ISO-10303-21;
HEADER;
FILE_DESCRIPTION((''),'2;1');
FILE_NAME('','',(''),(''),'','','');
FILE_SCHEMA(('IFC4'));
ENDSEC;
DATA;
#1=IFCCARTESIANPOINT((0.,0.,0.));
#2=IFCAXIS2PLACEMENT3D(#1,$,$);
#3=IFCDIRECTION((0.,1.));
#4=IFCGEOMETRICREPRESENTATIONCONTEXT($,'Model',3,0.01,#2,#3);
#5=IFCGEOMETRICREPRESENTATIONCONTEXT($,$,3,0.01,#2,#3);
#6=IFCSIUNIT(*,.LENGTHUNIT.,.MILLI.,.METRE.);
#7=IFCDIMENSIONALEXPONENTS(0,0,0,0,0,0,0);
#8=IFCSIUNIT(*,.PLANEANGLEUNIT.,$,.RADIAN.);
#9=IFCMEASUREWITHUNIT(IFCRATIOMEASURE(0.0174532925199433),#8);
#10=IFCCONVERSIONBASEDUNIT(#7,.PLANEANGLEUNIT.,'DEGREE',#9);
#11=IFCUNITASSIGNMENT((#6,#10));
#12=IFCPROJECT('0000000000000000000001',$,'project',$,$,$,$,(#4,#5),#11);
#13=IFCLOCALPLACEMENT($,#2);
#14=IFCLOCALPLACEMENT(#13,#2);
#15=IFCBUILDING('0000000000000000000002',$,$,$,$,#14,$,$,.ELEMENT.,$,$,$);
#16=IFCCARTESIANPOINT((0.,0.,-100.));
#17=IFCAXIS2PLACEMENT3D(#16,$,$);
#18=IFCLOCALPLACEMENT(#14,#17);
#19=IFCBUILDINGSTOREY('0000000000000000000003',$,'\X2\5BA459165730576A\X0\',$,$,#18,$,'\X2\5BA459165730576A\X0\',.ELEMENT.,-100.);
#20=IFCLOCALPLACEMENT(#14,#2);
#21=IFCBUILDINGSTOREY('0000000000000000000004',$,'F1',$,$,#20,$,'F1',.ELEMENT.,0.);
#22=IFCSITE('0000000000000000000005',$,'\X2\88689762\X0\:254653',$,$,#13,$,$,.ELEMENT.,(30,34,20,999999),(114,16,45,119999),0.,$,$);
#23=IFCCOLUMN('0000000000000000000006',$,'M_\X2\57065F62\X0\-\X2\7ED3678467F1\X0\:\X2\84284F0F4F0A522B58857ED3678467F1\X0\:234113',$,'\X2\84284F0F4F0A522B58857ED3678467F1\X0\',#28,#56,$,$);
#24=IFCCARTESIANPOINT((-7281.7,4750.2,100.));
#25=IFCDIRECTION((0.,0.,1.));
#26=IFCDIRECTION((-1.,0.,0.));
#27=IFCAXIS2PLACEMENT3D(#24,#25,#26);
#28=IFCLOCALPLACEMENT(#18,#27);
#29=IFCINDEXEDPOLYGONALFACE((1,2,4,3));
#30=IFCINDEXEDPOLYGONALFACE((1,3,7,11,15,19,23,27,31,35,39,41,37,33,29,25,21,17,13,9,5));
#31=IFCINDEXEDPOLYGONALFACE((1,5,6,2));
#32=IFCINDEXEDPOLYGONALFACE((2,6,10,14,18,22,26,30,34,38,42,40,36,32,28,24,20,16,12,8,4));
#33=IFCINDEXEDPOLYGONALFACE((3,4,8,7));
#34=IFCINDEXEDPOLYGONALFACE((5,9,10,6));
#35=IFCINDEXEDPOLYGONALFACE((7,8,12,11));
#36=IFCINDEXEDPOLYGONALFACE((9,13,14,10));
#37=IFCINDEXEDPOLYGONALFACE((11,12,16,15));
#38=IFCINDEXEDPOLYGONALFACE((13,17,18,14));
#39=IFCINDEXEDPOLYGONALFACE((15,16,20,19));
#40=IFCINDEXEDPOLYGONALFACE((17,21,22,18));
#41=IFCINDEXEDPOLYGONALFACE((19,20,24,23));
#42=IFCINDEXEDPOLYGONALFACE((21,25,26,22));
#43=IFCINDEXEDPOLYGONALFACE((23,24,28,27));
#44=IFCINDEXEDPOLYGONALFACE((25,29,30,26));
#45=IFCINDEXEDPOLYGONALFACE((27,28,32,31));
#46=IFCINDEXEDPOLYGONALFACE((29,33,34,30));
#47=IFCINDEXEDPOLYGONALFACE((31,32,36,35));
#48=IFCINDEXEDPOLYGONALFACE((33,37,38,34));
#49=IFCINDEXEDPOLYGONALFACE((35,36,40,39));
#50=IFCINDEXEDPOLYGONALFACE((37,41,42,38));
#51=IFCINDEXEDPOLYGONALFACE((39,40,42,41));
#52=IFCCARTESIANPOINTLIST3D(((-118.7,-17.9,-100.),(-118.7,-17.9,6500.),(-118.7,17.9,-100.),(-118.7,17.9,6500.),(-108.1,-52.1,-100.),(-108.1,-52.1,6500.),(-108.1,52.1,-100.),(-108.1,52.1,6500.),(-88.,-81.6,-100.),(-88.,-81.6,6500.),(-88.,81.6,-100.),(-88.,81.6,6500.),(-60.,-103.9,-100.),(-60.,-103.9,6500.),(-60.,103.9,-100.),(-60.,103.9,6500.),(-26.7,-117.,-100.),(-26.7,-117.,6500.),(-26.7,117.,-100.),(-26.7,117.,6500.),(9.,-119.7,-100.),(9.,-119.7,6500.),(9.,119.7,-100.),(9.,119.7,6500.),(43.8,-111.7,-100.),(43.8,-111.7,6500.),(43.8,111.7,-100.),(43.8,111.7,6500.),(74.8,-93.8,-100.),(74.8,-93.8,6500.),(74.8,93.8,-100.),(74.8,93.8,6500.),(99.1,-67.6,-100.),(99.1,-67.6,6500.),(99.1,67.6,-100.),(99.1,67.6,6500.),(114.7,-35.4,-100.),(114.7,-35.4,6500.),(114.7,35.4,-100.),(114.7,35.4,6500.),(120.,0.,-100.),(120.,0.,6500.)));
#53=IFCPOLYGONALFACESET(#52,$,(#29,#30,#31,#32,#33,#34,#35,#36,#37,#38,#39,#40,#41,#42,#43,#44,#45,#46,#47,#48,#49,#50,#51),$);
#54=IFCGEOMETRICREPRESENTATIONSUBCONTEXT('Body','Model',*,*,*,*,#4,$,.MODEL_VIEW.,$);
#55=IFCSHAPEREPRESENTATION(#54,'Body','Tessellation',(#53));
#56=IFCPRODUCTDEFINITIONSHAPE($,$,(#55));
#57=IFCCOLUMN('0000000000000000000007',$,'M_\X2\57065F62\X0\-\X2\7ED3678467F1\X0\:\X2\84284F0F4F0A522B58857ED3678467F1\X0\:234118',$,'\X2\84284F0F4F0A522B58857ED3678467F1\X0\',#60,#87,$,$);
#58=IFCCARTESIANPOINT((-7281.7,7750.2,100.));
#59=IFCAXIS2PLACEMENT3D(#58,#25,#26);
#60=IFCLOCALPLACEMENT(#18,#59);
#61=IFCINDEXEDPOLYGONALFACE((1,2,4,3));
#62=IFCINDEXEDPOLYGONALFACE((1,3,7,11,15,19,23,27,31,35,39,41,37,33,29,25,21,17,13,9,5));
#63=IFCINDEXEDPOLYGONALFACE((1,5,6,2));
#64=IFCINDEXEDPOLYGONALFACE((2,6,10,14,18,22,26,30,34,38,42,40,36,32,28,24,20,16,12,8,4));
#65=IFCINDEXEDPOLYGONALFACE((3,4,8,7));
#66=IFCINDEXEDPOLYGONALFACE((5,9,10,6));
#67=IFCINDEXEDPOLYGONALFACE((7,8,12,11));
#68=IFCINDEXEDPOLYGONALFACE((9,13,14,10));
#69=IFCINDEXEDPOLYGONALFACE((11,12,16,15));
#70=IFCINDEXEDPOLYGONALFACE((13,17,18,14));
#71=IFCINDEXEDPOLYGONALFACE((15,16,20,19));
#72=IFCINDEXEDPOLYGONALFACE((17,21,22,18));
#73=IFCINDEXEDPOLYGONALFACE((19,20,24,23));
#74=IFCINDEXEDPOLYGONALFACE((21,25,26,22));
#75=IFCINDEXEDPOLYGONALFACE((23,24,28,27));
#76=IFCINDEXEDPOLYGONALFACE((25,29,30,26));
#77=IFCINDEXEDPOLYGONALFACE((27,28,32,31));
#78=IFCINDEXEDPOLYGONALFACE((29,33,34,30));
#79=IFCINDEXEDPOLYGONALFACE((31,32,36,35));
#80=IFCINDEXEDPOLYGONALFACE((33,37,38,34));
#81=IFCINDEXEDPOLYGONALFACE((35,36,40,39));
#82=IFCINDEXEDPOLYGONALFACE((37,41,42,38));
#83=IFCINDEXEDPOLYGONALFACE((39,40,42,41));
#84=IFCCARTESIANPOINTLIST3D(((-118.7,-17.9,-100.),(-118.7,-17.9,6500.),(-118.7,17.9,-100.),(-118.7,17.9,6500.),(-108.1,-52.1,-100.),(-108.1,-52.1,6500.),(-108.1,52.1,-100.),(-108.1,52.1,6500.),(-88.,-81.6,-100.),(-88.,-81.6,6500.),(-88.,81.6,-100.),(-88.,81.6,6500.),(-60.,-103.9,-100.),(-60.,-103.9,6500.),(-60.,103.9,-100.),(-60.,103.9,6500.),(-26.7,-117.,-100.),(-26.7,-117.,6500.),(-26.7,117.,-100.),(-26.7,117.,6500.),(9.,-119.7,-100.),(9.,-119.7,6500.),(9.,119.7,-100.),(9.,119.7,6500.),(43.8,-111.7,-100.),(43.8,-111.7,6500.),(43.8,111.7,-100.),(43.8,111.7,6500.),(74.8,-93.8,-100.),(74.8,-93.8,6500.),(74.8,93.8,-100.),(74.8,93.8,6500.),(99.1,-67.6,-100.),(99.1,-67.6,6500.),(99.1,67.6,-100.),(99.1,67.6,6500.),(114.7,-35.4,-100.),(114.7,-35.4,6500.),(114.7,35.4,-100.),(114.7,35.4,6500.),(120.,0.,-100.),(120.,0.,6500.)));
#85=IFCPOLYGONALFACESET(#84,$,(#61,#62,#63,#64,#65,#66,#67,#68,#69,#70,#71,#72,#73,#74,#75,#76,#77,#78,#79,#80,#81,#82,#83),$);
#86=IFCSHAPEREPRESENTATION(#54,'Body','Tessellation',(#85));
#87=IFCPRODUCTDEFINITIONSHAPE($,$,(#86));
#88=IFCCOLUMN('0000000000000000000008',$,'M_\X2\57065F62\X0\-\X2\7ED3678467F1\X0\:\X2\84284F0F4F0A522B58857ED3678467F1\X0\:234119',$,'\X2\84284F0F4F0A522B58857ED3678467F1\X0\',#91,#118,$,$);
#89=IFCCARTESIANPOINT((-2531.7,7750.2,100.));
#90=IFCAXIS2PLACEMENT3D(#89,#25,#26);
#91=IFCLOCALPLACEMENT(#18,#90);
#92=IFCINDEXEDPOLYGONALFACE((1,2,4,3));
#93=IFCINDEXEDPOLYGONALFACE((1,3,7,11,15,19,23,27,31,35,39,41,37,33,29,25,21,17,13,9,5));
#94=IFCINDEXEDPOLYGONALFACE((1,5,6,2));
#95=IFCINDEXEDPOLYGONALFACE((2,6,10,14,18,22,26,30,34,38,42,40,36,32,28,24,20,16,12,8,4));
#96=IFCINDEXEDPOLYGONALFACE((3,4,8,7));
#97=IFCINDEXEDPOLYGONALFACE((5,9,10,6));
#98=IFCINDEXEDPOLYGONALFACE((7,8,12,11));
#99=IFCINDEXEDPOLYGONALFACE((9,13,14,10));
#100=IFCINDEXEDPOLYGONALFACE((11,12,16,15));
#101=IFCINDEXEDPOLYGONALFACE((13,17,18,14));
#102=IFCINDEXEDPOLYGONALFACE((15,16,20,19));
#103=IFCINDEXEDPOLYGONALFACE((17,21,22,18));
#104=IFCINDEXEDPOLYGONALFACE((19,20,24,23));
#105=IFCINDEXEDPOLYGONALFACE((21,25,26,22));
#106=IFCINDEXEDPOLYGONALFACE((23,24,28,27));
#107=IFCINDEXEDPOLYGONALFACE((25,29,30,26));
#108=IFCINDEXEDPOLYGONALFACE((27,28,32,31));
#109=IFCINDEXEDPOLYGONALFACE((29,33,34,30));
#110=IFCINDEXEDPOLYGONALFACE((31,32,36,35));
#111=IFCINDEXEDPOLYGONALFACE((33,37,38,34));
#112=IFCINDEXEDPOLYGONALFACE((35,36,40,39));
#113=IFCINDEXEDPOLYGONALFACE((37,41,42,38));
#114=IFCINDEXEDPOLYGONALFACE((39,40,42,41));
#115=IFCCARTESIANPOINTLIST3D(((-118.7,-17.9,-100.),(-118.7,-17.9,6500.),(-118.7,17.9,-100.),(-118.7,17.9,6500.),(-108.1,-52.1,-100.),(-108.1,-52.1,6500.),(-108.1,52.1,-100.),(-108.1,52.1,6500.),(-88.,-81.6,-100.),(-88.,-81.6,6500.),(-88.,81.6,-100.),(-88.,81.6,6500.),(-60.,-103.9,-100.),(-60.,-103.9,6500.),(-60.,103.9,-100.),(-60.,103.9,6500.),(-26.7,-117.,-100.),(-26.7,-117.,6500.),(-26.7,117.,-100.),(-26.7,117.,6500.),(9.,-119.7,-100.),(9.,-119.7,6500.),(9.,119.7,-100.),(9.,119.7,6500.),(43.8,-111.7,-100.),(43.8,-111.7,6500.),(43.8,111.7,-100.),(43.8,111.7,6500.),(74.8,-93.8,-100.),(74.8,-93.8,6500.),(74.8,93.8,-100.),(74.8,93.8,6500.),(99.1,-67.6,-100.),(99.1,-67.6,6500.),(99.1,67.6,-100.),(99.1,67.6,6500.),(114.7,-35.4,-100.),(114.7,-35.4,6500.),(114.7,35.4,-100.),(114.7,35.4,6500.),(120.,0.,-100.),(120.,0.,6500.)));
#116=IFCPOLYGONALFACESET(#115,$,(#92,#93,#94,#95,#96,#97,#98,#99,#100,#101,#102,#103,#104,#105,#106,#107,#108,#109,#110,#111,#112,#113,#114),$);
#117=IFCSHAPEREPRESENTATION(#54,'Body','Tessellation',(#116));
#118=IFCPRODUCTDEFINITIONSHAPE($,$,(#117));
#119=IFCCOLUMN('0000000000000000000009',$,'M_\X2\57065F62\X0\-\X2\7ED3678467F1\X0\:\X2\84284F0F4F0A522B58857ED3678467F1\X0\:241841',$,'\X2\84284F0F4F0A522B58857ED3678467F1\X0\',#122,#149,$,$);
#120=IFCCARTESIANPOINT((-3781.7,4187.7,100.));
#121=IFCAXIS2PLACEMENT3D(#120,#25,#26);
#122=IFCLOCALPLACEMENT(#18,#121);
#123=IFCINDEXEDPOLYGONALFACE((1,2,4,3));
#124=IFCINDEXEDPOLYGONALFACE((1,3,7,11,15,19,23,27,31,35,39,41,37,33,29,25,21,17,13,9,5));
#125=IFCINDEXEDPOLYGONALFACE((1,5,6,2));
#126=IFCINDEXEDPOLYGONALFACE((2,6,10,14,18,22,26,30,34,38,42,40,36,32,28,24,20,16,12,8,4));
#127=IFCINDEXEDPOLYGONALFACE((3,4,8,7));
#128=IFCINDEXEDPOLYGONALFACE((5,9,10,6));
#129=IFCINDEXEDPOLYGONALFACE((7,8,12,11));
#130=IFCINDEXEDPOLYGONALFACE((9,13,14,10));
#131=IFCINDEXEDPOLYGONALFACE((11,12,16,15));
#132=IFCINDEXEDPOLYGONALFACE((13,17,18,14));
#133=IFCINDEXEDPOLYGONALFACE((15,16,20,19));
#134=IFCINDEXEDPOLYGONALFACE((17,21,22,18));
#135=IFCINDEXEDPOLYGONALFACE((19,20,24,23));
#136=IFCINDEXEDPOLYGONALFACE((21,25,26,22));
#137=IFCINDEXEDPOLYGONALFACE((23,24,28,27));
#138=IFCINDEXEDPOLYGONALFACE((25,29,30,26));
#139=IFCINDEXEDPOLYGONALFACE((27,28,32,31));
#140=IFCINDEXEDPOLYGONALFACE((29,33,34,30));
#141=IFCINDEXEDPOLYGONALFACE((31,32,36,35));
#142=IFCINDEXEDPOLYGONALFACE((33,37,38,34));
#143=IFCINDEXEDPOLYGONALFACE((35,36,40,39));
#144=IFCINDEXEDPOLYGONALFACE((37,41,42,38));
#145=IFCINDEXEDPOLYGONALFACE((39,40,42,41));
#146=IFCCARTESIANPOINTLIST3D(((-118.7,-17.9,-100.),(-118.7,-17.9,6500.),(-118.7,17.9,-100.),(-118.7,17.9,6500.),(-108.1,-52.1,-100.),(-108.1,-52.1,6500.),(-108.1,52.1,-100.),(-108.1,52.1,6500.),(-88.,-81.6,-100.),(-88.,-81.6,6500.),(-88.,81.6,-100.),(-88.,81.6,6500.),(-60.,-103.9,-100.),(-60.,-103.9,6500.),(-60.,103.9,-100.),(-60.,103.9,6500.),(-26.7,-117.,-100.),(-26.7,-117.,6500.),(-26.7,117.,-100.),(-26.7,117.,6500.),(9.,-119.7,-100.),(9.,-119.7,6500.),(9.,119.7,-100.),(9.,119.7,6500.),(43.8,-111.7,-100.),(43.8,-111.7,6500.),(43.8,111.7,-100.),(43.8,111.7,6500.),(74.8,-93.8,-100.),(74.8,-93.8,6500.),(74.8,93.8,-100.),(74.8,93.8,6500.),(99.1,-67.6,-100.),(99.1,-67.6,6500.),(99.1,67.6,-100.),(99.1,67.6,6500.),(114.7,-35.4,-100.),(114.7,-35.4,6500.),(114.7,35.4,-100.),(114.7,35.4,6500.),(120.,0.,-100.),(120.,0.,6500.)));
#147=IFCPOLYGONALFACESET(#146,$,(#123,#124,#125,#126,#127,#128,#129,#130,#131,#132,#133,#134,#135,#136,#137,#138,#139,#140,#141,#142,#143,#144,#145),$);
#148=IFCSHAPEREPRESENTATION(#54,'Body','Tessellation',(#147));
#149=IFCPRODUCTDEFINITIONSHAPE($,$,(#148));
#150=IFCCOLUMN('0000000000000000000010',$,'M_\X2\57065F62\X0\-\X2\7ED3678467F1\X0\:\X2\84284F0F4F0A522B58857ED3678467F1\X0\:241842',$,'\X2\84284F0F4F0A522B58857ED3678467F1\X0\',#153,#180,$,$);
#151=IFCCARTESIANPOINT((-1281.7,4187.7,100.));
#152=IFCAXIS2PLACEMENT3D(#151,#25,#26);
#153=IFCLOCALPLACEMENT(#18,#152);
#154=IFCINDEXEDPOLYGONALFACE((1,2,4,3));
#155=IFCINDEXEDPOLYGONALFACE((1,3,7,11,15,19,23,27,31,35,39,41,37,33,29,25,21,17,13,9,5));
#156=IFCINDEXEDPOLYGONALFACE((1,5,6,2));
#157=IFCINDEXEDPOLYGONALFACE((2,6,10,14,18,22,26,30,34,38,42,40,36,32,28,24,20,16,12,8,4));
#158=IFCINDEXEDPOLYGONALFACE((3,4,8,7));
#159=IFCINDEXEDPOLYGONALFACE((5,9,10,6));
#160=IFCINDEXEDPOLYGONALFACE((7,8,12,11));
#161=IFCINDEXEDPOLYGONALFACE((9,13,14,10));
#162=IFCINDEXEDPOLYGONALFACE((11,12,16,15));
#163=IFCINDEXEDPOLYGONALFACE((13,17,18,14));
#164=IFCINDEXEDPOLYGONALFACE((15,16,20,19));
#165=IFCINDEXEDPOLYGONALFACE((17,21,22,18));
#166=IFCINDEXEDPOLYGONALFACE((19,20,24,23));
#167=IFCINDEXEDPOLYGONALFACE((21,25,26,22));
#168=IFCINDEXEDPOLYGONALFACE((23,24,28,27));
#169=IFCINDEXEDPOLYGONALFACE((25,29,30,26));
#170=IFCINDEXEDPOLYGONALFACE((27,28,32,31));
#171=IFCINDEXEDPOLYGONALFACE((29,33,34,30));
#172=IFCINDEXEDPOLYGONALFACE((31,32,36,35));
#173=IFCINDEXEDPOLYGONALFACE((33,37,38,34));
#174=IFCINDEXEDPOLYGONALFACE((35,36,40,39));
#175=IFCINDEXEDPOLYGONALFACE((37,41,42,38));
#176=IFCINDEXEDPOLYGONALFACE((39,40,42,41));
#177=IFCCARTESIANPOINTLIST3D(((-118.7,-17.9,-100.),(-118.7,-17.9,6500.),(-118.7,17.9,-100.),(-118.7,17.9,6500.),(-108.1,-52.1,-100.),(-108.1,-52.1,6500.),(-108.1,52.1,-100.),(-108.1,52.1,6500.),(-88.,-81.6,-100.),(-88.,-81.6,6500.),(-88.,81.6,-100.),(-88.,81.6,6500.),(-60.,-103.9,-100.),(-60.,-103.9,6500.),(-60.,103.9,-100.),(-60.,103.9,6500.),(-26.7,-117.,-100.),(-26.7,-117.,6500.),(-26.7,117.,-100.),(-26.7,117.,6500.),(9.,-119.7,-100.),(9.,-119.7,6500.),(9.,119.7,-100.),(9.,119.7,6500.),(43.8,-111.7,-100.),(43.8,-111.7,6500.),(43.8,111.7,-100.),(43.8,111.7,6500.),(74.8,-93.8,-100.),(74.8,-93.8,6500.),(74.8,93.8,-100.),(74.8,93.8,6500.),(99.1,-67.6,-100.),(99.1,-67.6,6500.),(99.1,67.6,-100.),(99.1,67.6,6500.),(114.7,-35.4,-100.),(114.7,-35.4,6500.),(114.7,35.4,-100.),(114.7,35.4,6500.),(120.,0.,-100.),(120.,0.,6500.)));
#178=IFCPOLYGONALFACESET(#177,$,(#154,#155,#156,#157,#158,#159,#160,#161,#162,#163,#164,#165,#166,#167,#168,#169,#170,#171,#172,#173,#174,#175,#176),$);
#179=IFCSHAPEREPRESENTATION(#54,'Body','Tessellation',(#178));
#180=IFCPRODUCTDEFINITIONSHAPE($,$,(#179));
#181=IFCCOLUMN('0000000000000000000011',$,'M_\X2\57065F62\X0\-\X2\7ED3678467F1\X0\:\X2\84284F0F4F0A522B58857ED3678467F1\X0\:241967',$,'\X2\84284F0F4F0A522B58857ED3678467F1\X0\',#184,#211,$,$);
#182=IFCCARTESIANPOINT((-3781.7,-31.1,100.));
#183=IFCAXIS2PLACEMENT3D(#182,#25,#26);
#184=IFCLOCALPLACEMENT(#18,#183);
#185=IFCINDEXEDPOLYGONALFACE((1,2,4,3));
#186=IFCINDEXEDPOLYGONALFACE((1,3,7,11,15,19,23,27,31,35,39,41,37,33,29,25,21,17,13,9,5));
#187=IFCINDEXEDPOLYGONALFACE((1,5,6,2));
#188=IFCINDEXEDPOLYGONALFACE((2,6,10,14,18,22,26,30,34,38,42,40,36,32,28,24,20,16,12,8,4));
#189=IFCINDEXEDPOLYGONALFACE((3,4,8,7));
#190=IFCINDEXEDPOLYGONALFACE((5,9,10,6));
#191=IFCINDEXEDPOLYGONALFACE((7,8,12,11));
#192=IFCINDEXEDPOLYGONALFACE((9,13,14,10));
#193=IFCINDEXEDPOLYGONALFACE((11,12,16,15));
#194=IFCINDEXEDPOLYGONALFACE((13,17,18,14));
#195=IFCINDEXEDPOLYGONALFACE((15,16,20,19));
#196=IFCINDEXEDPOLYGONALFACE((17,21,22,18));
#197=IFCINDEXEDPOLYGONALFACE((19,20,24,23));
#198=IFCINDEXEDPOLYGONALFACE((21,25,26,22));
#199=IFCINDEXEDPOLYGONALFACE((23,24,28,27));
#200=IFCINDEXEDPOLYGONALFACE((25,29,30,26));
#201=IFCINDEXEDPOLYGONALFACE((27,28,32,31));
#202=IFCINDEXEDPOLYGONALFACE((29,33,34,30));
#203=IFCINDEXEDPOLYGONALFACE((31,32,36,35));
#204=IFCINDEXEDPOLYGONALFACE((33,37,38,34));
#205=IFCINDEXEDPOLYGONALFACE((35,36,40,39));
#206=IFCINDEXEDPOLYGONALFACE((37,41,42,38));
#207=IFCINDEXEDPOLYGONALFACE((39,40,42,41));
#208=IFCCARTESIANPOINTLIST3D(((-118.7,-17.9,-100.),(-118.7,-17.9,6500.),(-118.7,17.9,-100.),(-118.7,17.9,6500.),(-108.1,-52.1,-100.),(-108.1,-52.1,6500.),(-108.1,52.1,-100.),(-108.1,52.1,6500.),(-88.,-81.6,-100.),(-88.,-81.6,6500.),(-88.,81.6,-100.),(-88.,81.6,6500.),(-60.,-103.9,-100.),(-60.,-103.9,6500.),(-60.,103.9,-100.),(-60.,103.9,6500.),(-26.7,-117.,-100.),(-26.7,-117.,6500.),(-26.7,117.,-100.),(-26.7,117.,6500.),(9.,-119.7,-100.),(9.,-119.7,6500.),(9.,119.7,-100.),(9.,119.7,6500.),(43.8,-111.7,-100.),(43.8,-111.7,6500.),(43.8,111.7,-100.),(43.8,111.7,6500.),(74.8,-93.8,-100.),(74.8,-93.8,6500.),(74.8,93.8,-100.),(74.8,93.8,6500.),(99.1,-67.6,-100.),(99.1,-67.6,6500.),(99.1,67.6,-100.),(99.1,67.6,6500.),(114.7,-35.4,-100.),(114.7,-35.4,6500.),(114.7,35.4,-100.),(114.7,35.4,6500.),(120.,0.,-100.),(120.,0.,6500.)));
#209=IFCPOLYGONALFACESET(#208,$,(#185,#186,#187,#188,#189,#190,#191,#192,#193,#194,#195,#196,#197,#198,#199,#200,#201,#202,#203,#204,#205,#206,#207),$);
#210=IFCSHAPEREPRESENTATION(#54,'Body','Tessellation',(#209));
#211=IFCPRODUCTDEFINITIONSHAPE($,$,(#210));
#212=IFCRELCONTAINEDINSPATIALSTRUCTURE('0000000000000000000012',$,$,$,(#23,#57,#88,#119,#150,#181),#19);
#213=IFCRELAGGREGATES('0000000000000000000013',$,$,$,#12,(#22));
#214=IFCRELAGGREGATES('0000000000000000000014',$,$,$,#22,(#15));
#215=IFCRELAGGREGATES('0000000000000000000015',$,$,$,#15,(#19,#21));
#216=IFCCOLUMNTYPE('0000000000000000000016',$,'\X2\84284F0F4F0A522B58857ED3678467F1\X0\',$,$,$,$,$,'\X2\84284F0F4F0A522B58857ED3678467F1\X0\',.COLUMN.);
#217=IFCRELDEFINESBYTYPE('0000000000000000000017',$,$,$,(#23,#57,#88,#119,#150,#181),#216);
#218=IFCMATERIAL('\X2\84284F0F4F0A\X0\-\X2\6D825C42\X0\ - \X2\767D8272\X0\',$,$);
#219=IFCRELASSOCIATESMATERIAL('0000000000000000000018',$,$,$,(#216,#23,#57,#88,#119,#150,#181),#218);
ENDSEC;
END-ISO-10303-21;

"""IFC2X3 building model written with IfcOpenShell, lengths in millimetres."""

from ifc_helpers import new_model, entity, si_unit, converted_unit, direction, frame, frame_2d, origin, place, context, subcontext, project, spatial, circle, extrude, source, transform, mapped, material, type_object, type_shapes, element, save


model = new_model("IFC2X3")

# Units and contexts
model_context = context("Model", 3, precision=0.01, world=origin(), true_north=direction((0.0, 1.0)))
context_of_model = context(None, 3, precision=0.01, world=origin(), true_north=direction((0.0, 1.0)))
body_context = subcontext(model_context, "Body", "Model", "MODEL_VIEW")
ifc_project = project(units=[si_unit("LENGTHUNIT", "METRE", prefix="MILLI"), converted_unit("PLANEANGLEUNIT", "DEGREE", entity("IfcRatioMeasure", 0.0174532925199433), si_unit("PLANEANGLEUNIT", "RADIAN"), dimensions=[0, 0, 0, 0, 0, 0, 0])], contexts=[model_context, context_of_model])

# Site, building, storey
site_placement = place(None, origin())
site = spatial("IfcSite", under=ifc_project, at=site_placement, Name="表面:254653", CompositionType="ELEMENT", RefLatitude=(30, 34, 20, 999999), RefLongitude=(114, 16, 45, 119999), RefElevation=0.0)
building_placement = place(site_placement, origin())
building = spatial("IfcBuilding", under=site, at=building_placement, CompositionType="ELEMENT")
storey_1_placement = place(building_placement, frame((0.0, 0.0, -100.0)))
storey_1 = spatial("IfcBuildingStorey", under=building, at=storey_1_placement, Name="室外地坪", LongName="室外地坪", CompositionType="ELEMENT", Elevation=-100.0)

# Columns
ifc_material_1 = material(Name="萨伏伊-涂层 - 白色")
column_type_1 = type_object("IfcColumnType", Name="萨伏伊别墅结构柱", ElementType="萨伏伊别墅结构柱", PredefinedType="COLUMN", material=ifc_material_1)
shared_shape_1 = source(origin(), body_context, "Body", "SweptSolid", [
    extrude(circle(Radius=120.0, at=frame_2d((0.0, 0.0), x_axis=(1.0, 0.0))), frame((0.0, 0.0, -100.0)), (0.0, 0.0, 1.0), 6600.0),
])
type_shapes(column_type_1, [shared_shape_1])
for number, where, z_axis, x_axis, name in (
    (1, (-7281.7, 4750.2, 100.0), (0.0, 0.0, 1.0), (-1.0, 0.0, 0.0), "M_圆形-结构柱:萨伏伊别墅结构柱:234113"),
    (2, (-7281.7, 7750.2, 100.0), (0.0, 0.0, 1.0), (-1.0, 0.0, 0.0), "M_圆形-结构柱:萨伏伊别墅结构柱:234118"),
    (3, (-2531.7, 7750.2, 100.0), (0.0, 0.0, 1.0), (-1.0, 0.0, 0.0), "M_圆形-结构柱:萨伏伊别墅结构柱:234119"),
    (4, (-3781.7, 4187.7, 100.0), (0.0, 0.0, 1.0), (-1.0, 0.0, 0.0), "M_圆形-结构柱:萨伏伊别墅结构柱:241841"),
    (5, (-1281.7, 4187.7, 100.0), (0.0, 0.0, 1.0), (-1.0, 0.0, 0.0), "M_圆形-结构柱:萨伏伊别墅结构柱:241842"),
    (6, (-3781.7, -31.1, 100.0), (0.0, 0.0, 1.0), (-1.0, 0.0, 0.0), "M_圆形-结构柱:萨伏伊别墅结构柱:241967"),
):
    element("IfcColumn", number, at=place(storey_1_placement, frame(where, z_axis=z_axis, x_axis=x_axis)), inside=storey_1, type_object=column_type_1, material=ifc_material_1, Name=name, ObjectType="萨伏伊别墅结构柱", context=body_context, shape_type="MappedRepresentation", body=[
        mapped(shared_shape_1, transform((0.0, 0.0, 0.0), scale=1.0)),
    ])

# Shared definitions
storey_2_placement = place(building_placement, origin())
storey_2 = spatial("IfcBuildingStorey", under=building, at=storey_2_placement, Name="F1", LongName="F1", CompositionType="ELEMENT", Elevation=0.0)

save(model, "model.ifc")
